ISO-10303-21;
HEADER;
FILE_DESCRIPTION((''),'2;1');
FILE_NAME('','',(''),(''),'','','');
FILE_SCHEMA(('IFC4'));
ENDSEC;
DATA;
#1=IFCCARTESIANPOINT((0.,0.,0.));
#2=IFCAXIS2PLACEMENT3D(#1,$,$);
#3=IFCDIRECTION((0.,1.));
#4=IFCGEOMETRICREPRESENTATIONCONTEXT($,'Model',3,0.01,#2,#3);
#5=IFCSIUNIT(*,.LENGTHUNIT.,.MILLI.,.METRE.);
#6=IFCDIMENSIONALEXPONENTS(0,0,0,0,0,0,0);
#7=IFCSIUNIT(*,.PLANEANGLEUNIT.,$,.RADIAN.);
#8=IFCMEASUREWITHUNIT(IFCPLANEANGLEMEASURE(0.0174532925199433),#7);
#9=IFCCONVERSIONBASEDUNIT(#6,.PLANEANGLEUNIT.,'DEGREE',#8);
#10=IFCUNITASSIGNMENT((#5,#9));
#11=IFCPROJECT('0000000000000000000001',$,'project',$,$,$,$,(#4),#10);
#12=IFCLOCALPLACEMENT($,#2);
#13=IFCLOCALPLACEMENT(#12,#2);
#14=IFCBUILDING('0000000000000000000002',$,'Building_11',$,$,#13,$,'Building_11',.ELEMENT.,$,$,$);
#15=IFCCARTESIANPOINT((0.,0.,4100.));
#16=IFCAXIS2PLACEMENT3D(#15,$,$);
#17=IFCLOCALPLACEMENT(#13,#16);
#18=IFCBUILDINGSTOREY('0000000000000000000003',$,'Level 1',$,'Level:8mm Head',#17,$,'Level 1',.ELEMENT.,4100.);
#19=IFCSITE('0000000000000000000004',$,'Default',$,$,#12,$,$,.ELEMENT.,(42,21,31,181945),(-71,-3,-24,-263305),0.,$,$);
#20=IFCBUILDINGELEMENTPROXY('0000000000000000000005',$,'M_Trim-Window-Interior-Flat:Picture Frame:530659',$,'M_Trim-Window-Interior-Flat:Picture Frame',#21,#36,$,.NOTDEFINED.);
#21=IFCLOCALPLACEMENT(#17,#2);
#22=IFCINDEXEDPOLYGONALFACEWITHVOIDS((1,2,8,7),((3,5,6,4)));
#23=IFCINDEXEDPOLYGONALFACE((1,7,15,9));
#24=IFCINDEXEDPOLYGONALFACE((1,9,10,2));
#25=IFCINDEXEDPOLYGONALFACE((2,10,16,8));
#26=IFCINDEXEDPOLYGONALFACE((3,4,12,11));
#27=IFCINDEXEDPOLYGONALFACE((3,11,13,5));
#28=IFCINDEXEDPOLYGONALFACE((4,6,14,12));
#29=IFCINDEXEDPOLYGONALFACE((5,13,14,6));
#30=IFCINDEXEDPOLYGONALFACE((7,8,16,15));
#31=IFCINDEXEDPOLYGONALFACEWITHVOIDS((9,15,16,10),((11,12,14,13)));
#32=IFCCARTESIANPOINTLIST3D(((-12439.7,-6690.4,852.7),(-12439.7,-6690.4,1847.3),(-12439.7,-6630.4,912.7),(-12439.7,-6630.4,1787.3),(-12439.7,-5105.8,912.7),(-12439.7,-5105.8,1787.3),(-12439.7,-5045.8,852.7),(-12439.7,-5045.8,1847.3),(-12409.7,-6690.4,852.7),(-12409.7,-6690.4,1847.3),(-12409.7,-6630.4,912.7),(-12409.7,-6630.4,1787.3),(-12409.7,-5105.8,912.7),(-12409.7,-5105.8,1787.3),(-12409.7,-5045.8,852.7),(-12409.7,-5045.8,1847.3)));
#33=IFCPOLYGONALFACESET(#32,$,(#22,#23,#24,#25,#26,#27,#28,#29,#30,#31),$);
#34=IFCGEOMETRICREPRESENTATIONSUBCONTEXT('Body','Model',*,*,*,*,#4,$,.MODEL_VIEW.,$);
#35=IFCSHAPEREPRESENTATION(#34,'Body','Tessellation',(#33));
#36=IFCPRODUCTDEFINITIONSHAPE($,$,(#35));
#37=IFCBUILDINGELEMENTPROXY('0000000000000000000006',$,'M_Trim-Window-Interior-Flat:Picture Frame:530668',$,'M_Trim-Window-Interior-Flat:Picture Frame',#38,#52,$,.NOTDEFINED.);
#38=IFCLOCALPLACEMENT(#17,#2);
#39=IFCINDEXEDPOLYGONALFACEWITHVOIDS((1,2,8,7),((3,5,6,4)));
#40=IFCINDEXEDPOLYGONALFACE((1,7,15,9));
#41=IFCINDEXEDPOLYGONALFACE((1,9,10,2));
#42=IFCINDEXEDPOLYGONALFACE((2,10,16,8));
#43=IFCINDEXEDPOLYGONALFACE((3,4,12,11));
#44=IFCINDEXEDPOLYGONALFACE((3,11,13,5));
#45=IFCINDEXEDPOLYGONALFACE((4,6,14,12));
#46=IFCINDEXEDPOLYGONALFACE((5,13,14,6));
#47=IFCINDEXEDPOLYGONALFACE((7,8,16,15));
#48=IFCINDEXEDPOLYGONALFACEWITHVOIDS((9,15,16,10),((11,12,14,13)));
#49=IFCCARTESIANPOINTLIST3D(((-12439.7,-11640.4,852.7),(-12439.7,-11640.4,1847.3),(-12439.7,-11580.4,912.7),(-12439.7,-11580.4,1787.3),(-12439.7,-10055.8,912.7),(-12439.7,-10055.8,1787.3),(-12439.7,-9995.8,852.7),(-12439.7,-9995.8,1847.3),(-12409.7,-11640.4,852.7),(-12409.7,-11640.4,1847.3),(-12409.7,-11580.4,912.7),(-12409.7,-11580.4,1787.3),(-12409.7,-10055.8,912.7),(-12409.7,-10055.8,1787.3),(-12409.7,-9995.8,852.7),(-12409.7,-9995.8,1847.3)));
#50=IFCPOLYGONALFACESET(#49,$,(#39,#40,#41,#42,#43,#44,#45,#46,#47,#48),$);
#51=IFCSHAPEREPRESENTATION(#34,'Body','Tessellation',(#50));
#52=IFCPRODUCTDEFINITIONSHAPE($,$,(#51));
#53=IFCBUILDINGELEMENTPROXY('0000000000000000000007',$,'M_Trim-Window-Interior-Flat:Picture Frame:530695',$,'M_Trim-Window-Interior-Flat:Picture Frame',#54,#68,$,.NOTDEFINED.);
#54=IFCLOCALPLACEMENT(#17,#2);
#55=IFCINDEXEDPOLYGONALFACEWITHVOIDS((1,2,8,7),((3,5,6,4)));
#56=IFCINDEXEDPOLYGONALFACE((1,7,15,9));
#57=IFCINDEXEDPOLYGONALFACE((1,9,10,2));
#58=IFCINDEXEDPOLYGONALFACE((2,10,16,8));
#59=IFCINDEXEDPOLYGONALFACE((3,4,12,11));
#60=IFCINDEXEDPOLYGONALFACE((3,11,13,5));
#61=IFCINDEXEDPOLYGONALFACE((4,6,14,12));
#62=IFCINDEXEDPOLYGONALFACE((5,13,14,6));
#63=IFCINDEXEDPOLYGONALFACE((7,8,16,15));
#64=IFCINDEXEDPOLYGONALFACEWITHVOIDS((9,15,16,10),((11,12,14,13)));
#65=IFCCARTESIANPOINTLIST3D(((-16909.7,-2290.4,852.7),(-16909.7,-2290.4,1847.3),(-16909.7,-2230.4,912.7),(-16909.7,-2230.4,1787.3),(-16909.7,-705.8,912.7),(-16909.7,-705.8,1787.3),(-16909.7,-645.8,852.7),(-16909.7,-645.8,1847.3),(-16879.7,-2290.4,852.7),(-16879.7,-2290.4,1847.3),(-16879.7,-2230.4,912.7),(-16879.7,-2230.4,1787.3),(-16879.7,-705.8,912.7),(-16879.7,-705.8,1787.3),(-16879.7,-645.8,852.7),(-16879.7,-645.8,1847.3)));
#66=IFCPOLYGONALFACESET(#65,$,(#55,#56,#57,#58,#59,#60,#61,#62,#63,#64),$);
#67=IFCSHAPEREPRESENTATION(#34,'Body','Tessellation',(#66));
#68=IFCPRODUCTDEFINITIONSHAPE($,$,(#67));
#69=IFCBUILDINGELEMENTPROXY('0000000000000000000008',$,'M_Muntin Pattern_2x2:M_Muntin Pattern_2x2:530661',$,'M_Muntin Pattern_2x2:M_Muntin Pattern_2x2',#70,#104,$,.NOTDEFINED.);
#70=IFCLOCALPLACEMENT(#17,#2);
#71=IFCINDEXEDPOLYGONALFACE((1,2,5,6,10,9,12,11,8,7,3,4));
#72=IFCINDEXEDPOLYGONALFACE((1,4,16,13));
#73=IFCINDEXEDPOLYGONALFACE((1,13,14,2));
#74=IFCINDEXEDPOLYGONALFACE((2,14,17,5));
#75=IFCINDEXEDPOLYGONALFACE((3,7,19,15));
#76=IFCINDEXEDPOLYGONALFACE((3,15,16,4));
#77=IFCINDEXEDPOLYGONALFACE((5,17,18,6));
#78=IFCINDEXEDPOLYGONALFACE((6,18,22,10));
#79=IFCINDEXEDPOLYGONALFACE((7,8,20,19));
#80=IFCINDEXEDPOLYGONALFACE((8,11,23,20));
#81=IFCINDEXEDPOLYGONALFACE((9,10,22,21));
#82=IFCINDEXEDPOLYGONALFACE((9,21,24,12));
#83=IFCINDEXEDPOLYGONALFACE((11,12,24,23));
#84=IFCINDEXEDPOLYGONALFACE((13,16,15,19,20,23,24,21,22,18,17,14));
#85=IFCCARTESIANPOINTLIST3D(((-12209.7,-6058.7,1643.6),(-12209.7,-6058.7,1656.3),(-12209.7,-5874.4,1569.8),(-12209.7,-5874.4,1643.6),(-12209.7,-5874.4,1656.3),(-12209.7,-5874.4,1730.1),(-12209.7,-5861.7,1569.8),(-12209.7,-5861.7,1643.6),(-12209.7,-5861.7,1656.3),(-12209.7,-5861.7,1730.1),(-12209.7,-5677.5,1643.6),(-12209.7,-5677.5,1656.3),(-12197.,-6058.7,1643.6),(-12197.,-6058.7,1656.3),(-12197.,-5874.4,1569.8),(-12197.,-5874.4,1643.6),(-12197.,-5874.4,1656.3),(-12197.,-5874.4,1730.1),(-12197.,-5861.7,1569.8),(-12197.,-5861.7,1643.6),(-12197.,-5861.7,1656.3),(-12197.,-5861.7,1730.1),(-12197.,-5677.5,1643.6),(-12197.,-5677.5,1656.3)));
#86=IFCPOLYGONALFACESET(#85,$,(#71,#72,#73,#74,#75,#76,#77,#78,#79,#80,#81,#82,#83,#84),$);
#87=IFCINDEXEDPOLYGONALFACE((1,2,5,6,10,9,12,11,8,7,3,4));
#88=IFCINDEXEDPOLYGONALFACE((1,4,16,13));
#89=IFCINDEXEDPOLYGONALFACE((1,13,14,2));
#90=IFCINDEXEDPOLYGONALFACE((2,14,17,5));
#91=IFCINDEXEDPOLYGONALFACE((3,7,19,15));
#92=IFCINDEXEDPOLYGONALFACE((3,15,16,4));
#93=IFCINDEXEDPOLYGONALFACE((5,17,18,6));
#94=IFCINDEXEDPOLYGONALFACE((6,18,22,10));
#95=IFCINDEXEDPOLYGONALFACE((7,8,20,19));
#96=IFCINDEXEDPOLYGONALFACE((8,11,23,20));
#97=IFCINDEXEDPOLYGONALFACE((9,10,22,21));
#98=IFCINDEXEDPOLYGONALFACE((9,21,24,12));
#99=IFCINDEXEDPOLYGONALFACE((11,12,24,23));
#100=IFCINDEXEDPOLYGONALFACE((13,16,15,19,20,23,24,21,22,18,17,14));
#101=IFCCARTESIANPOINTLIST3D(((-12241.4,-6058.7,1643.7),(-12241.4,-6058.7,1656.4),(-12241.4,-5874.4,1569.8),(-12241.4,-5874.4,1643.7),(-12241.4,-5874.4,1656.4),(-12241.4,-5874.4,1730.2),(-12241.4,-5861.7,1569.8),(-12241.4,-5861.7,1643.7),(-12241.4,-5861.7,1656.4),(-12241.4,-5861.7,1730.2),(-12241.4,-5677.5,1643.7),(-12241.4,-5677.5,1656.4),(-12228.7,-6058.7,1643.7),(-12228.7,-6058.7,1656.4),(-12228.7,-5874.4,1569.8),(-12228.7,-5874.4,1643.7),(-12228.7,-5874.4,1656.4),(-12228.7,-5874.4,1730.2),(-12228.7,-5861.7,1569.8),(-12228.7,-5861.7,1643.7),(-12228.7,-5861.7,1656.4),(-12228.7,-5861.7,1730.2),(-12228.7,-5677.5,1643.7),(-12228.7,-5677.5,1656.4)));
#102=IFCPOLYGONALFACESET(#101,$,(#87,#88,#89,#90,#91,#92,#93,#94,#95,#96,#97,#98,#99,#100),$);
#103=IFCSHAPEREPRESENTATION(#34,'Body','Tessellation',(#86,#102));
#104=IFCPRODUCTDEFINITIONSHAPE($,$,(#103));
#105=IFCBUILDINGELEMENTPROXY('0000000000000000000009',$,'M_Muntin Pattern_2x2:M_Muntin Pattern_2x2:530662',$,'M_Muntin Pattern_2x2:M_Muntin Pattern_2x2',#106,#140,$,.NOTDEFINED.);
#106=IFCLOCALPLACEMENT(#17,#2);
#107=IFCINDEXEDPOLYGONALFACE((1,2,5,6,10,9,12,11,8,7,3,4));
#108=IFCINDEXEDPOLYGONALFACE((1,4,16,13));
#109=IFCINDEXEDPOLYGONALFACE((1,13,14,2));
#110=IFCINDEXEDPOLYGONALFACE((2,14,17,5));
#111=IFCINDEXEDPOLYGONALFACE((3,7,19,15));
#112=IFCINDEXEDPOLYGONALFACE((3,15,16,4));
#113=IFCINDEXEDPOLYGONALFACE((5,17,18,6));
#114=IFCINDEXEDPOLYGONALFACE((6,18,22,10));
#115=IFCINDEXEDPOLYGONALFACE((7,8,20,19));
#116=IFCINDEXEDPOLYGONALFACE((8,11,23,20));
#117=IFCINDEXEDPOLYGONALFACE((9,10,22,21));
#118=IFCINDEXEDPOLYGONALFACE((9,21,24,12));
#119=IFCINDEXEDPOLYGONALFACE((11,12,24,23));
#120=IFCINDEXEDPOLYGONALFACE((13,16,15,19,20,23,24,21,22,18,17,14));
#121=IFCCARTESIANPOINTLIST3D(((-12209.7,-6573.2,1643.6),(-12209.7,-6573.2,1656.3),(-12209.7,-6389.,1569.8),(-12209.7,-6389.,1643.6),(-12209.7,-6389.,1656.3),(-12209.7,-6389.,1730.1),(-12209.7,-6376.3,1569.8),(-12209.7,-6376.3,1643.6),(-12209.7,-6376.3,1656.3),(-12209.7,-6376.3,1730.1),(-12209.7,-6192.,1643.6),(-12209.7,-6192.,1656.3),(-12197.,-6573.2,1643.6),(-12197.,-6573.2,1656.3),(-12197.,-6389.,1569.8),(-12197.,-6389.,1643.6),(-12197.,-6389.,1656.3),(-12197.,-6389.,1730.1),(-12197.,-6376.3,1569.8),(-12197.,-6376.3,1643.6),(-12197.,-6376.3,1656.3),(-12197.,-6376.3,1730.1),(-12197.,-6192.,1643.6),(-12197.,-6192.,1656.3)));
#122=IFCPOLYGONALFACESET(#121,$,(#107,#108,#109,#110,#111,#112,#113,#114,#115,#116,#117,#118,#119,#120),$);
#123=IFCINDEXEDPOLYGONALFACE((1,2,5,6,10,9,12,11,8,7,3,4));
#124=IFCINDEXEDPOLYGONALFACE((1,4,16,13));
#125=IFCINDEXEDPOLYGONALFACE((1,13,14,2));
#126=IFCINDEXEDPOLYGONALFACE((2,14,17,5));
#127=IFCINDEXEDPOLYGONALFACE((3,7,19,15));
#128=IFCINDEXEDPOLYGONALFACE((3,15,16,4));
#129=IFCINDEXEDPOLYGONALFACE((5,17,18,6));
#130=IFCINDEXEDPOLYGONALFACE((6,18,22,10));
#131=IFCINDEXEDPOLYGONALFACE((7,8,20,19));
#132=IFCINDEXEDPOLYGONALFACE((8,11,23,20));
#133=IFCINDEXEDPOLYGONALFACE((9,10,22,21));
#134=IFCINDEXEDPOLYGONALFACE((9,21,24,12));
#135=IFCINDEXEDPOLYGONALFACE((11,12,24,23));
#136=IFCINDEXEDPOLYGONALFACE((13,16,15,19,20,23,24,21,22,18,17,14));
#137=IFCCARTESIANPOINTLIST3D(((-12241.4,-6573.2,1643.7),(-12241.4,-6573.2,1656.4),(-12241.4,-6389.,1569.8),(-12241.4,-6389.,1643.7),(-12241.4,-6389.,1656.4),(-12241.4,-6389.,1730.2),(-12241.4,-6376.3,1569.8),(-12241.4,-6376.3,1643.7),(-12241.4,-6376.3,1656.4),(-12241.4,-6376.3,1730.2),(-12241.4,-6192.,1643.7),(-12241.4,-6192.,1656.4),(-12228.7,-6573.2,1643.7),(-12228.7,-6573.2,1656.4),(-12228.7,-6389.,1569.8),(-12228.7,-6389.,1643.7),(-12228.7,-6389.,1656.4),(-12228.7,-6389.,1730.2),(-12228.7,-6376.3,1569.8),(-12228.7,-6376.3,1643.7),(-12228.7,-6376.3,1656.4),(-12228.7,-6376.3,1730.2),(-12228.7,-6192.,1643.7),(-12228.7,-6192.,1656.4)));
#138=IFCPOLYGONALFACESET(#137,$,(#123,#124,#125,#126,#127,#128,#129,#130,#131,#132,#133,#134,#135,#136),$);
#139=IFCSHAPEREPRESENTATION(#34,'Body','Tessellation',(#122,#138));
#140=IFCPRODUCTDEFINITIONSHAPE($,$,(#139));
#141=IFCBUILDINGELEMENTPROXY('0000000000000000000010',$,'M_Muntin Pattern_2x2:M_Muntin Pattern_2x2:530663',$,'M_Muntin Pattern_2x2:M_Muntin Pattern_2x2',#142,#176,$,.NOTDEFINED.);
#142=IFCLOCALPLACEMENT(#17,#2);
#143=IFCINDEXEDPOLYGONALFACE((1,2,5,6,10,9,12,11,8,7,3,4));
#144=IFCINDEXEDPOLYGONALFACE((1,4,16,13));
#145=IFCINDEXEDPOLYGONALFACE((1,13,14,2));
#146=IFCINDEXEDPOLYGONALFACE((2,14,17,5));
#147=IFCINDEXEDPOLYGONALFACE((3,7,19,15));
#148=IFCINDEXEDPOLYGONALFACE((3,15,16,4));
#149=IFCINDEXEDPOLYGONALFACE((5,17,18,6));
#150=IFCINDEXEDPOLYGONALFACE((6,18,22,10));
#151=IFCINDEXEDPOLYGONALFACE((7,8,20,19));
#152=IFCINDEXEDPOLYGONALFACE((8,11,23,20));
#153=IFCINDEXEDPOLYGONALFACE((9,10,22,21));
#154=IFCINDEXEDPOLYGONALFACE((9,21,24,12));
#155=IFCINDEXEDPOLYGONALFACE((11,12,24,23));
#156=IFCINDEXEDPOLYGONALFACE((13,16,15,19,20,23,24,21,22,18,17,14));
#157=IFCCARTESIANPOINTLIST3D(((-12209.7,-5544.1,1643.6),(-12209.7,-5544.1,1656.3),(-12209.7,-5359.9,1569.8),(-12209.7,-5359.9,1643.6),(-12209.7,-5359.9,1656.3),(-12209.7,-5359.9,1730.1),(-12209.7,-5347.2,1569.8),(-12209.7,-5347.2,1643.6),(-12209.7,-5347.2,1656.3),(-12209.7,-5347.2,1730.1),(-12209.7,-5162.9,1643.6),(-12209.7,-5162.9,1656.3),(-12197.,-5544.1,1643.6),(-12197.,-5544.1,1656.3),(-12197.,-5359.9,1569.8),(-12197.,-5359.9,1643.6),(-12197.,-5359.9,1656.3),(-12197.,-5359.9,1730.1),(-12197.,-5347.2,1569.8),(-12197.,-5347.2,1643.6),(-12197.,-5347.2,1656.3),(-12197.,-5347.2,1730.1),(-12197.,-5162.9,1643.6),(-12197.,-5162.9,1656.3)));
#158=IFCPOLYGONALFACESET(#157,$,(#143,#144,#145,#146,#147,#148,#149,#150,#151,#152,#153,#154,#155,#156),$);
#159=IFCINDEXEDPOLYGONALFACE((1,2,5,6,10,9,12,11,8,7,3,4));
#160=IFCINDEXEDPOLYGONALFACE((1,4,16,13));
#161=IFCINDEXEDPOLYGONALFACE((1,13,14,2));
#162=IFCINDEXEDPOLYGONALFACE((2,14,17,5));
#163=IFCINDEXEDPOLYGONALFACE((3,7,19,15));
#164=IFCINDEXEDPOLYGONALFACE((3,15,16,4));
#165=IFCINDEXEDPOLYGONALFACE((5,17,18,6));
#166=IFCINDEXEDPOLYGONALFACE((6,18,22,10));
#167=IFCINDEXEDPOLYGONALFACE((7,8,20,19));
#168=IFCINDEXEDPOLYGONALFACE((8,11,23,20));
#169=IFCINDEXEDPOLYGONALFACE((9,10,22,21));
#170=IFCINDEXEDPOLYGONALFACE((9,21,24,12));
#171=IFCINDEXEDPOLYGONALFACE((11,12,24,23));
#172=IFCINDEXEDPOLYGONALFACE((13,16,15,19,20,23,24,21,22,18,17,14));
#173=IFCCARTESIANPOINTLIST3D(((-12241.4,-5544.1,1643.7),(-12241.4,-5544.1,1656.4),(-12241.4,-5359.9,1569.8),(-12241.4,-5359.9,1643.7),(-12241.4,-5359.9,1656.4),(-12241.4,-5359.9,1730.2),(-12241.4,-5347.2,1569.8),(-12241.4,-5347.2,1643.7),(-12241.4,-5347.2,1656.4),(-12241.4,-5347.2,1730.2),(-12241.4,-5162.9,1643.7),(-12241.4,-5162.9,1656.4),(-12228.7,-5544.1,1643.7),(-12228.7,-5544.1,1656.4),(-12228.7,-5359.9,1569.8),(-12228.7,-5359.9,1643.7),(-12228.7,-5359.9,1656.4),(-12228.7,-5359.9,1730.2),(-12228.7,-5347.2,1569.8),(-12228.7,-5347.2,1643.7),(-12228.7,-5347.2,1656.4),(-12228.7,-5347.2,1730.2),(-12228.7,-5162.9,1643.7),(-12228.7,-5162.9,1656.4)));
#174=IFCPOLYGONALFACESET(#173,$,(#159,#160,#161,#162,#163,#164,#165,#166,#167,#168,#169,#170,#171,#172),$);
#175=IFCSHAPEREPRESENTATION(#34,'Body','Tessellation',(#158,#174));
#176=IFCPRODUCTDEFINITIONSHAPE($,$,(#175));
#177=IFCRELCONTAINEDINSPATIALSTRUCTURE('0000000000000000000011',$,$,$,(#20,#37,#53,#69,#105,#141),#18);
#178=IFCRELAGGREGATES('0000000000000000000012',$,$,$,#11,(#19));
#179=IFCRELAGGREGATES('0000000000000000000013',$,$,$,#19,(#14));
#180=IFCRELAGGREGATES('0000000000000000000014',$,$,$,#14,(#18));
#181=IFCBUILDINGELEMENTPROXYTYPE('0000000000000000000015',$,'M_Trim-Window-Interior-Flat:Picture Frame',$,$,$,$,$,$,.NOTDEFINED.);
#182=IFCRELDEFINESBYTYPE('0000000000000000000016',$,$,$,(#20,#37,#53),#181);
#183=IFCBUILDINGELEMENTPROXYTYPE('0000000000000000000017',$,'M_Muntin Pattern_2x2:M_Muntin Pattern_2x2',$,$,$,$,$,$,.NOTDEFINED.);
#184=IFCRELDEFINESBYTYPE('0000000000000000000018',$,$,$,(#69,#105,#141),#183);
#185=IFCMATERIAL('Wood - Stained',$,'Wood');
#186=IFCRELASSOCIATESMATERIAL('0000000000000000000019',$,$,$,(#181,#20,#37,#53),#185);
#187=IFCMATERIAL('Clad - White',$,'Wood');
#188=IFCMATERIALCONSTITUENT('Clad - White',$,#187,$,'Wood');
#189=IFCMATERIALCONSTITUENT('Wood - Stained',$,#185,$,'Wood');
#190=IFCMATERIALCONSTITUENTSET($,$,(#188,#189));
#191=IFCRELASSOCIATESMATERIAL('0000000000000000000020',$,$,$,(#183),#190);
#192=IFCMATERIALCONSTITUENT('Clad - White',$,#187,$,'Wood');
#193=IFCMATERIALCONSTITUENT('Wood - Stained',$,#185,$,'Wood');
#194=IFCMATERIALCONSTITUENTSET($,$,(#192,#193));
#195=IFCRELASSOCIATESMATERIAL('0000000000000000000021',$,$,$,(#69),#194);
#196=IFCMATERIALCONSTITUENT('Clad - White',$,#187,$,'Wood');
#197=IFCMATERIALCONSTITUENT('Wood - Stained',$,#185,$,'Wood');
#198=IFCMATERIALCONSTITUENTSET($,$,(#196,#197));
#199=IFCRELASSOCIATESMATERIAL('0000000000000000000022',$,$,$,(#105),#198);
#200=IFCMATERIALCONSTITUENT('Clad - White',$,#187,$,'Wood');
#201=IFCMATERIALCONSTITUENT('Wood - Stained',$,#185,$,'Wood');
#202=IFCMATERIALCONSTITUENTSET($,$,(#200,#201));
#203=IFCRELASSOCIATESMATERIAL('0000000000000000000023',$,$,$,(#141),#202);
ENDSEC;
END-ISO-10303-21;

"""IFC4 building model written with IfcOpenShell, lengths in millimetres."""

from ifc_helpers import new_model, entity, si_unit, converted_unit, direction, frame, origin, place, context, subcontext, project, spatial, indexed_curve, outline, extrude, source, transform, mapped, material, constituent, constituent_set, type_object, type_shapes, element, save


model = new_model("IFC4")

# Units and contexts
model_context = context("Model", 3, precision=0.01, world=origin(), true_north=direction((0.0, 1.0)))
body_context = subcontext(model_context, "Body", "Model", "MODEL_VIEW")
ifc_project = project(units=[si_unit("LENGTHUNIT", "METRE", prefix="MILLI"), converted_unit("PLANEANGLEUNIT", "DEGREE", entity("IfcPlaneAngleMeasure", 0.0174532925199433), si_unit("PLANEANGLEUNIT", "RADIAN"), dimensions=[0, 0, 0, 0, 0, 0, 0])], contexts=[model_context])

# Site, building, storey
site_placement = place(None, origin())
site = spatial("IfcSite", under=ifc_project, at=site_placement, Name="Default", CompositionType="ELEMENT", RefLatitude=(42, 21, 31, 181945), RefLongitude=(-71, -3, -24, -263305), RefElevation=0.0)
building_placement = place(site_placement, origin())
building = spatial("IfcBuilding", under=site, at=building_placement, Name="Building_11", LongName="Building_11", CompositionType="ELEMENT")
storey_placement = place(building_placement, frame((0.0, 0.0, 4100.0)))
storey = spatial("IfcBuildingStorey", under=building, at=storey_placement, Name="Level 1", ObjectType="Level:8mm Head", LongName="Level 1", CompositionType="ELEMENT", Elevation=4100.0)

# Building element proxies
ifc_material_1 = material(Name="Clad - White", Category="Wood")
ifc_material_2 = material(Name="Wood - Stained", Category="Wood")
building_element_proxy_type_1 = type_object("IfcBuildingElementProxyType", Name="M_Trim-Window-Interior-Flat:Picture Frame", PredefinedType="NOTDEFINED", material=ifc_material_2)
shared_shape_1 = source(origin(), body_context, "Body", "SweptSolid", [
    extrude(outline(indexed_curve([(-822.3, -497.3), (822.3, -497.3), (822.3, 497.3), (-822.3, 497.3), (-822.3, -497.3)], self_intersect=False), holes=[indexed_curve([(-762.3, -437.3), (-762.3, 437.3), (762.3, 437.3), (762.3, -437.3), (-762.3, -437.3)], self_intersect=False)]), frame((0.0, -450.0, 0.0), z_axis=(0.0, 0.0, 1.0), x_axis=(-1.0, 0.0, 0.0)), (0.0, 0.0, 1.0), 30.0),
])
type_shapes(building_element_proxy_type_1, [shared_shape_1])
for number, where, z_axis, x_axis, name in (
    (1, (-12409.7, -5868.1, 1800.0), (-1.0, 0.0, 0.0), (0.0, -1.0, 0.0), "M_Trim-Window-Interior-Flat:Picture Frame:530659"),
    (2, (-12409.7, -10818.1, 1800.0), (-1.0, 0.0, 0.0), (0.0, -1.0, 0.0), "M_Trim-Window-Interior-Flat:Picture Frame:530668"),
    (3, (-16909.7, -1468.1, 1800.0), (1.0, 0.0, 0.0), (0.0, 1.0, 0.0), "M_Trim-Window-Interior-Flat:Picture Frame:530695"),
):
    element("IfcBuildingElementProxy", number, at=place(storey_placement, frame(where, z_axis=z_axis, x_axis=x_axis)), inside=storey, type_object=building_element_proxy_type_1, material=ifc_material_2, Name=name, ObjectType="M_Trim-Window-Interior-Flat:Picture Frame", PredefinedType="NOTDEFINED", context=body_context, shape_type="MappedRepresentation", body=[
        mapped(shared_shape_1, transform((0.0, 0.0, 0.0), scale=1.0)),
    ])
ifc_constituent_1 = constituent(ifc_material_1, Name="Clad - White", Category="Wood")
ifc_constituent_2 = constituent(ifc_material_2, Name="Wood - Stained", Category="Wood")
ifc_constituent_set_1 = constituent_set(constituents=[ifc_constituent_1, ifc_constituent_2])
ifc_constituent_3 = constituent(ifc_material_1, Name="Clad - White", Category="Wood")
ifc_constituent_4 = constituent(ifc_material_2, Name="Wood - Stained", Category="Wood")
ifc_constituent_set_2 = constituent_set(constituents=[ifc_constituent_3, ifc_constituent_4])
building_element_proxy_type_2 = type_object("IfcBuildingElementProxyType", Name="M_Muntin Pattern_2x2:M_Muntin Pattern_2x2", PredefinedType="NOTDEFINED", material=ifc_constituent_set_2)
shared_shape_2 = source(origin(), body_context, "Body", "SweptSolid", [
    extrude(outline(indexed_curve([(6.4, -6.4), (80.1, -6.4), (80.1, 6.3), (6.4, 6.3), (6.4, 190.6), (-6.3, 190.6), (-6.3, 6.3), (-80.2, 6.3), (-80.2, -6.4), (-6.3, -6.4), (-6.3, -190.6), (6.4, -190.6), (6.4, -6.4)], self_intersect=False)), frame((0.0, 9.5, 80.1), z_axis=(0.0, 1.0, 0.0), x_axis=(0.0, 0.0, 1.0)), (0.0, 0.0, 1.0), 12.7),
    extrude(outline(indexed_curve([(6.4, -6.4), (80.2, -6.4), (80.2, 6.3), (6.4, 6.3), (6.4, 190.6), (-6.3, 190.6), (-6.3, 6.3), (-80.2, 6.3), (-80.2, -6.4), (-6.3, -6.4), (-6.3, -190.6), (6.4, -190.6), (6.4, -6.4)], self_intersect=False)), frame((0.0, -22.2, 80.2), z_axis=(0.0, 1.0, 0.0), x_axis=(0.0, 0.0, 1.0)), (0.0, 0.0, 1.0), 12.7),
])
type_shapes(building_element_proxy_type_2, [shared_shape_2])
proxy_1_placement = place(storey_placement, frame((-12219.2, -5868.1, 1569.8), z_axis=(0.0, 0.0, 1.0), x_axis=(0.0, -1.0, 0.0)))
element("IfcBuildingElementProxy", 4, at=proxy_1_placement, inside=storey, type_object=building_element_proxy_type_2, material=ifc_constituent_set_1, Name="M_Muntin Pattern_2x2:M_Muntin Pattern_2x2:530661", ObjectType="M_Muntin Pattern_2x2:M_Muntin Pattern_2x2", PredefinedType="NOTDEFINED", context=body_context, shape_type="MappedRepresentation", body=[
    mapped(shared_shape_2, transform((0.0, 0.0, 0.0), scale=1.0)),
])
ifc_constituent_5 = constituent(ifc_material_1, Name="Clad - White", Category="Wood")
ifc_constituent_6 = constituent(ifc_material_2, Name="Wood - Stained", Category="Wood")
ifc_constituent_set_3 = constituent_set(constituents=[ifc_constituent_5, ifc_constituent_6])
proxy_2_placement = place(storey_placement, frame((-12219.2, -6382.6, 1569.8), z_axis=(0.0, 0.0, 1.0), x_axis=(0.0, -1.0, 0.0)))
element("IfcBuildingElementProxy", 5, at=proxy_2_placement, inside=storey, type_object=building_element_proxy_type_2, material=ifc_constituent_set_3, Name="M_Muntin Pattern_2x2:M_Muntin Pattern_2x2:530662", ObjectType="M_Muntin Pattern_2x2:M_Muntin Pattern_2x2", PredefinedType="NOTDEFINED", context=body_context, shape_type="MappedRepresentation", body=[
    mapped(shared_shape_2, transform((0.0, 0.0, 0.0), scale=1.0)),
])
ifc_constituent_7 = constituent(ifc_material_1, Name="Clad - White", Category="Wood")
ifc_constituent_8 = constituent(ifc_material_2, Name="Wood - Stained", Category="Wood")
ifc_constituent_set_4 = constituent_set(constituents=[ifc_constituent_7, ifc_constituent_8])
proxy_3_placement = place(storey_placement, frame((-12219.2, -5353.5, 1569.8), z_axis=(0.0, 0.0, 1.0), x_axis=(0.0, -1.0, 0.0)))
element("IfcBuildingElementProxy", 6, at=proxy_3_placement, inside=storey, type_object=building_element_proxy_type_2, material=ifc_constituent_set_4, Name="M_Muntin Pattern_2x2:M_Muntin Pattern_2x2:530663", ObjectType="M_Muntin Pattern_2x2:M_Muntin Pattern_2x2", PredefinedType="NOTDEFINED", context=body_context, shape_type="MappedRepresentation", body=[
    mapped(shared_shape_2, transform((0.0, 0.0, 0.0), scale=1.0)),
])

save(model, "model.ifc")
